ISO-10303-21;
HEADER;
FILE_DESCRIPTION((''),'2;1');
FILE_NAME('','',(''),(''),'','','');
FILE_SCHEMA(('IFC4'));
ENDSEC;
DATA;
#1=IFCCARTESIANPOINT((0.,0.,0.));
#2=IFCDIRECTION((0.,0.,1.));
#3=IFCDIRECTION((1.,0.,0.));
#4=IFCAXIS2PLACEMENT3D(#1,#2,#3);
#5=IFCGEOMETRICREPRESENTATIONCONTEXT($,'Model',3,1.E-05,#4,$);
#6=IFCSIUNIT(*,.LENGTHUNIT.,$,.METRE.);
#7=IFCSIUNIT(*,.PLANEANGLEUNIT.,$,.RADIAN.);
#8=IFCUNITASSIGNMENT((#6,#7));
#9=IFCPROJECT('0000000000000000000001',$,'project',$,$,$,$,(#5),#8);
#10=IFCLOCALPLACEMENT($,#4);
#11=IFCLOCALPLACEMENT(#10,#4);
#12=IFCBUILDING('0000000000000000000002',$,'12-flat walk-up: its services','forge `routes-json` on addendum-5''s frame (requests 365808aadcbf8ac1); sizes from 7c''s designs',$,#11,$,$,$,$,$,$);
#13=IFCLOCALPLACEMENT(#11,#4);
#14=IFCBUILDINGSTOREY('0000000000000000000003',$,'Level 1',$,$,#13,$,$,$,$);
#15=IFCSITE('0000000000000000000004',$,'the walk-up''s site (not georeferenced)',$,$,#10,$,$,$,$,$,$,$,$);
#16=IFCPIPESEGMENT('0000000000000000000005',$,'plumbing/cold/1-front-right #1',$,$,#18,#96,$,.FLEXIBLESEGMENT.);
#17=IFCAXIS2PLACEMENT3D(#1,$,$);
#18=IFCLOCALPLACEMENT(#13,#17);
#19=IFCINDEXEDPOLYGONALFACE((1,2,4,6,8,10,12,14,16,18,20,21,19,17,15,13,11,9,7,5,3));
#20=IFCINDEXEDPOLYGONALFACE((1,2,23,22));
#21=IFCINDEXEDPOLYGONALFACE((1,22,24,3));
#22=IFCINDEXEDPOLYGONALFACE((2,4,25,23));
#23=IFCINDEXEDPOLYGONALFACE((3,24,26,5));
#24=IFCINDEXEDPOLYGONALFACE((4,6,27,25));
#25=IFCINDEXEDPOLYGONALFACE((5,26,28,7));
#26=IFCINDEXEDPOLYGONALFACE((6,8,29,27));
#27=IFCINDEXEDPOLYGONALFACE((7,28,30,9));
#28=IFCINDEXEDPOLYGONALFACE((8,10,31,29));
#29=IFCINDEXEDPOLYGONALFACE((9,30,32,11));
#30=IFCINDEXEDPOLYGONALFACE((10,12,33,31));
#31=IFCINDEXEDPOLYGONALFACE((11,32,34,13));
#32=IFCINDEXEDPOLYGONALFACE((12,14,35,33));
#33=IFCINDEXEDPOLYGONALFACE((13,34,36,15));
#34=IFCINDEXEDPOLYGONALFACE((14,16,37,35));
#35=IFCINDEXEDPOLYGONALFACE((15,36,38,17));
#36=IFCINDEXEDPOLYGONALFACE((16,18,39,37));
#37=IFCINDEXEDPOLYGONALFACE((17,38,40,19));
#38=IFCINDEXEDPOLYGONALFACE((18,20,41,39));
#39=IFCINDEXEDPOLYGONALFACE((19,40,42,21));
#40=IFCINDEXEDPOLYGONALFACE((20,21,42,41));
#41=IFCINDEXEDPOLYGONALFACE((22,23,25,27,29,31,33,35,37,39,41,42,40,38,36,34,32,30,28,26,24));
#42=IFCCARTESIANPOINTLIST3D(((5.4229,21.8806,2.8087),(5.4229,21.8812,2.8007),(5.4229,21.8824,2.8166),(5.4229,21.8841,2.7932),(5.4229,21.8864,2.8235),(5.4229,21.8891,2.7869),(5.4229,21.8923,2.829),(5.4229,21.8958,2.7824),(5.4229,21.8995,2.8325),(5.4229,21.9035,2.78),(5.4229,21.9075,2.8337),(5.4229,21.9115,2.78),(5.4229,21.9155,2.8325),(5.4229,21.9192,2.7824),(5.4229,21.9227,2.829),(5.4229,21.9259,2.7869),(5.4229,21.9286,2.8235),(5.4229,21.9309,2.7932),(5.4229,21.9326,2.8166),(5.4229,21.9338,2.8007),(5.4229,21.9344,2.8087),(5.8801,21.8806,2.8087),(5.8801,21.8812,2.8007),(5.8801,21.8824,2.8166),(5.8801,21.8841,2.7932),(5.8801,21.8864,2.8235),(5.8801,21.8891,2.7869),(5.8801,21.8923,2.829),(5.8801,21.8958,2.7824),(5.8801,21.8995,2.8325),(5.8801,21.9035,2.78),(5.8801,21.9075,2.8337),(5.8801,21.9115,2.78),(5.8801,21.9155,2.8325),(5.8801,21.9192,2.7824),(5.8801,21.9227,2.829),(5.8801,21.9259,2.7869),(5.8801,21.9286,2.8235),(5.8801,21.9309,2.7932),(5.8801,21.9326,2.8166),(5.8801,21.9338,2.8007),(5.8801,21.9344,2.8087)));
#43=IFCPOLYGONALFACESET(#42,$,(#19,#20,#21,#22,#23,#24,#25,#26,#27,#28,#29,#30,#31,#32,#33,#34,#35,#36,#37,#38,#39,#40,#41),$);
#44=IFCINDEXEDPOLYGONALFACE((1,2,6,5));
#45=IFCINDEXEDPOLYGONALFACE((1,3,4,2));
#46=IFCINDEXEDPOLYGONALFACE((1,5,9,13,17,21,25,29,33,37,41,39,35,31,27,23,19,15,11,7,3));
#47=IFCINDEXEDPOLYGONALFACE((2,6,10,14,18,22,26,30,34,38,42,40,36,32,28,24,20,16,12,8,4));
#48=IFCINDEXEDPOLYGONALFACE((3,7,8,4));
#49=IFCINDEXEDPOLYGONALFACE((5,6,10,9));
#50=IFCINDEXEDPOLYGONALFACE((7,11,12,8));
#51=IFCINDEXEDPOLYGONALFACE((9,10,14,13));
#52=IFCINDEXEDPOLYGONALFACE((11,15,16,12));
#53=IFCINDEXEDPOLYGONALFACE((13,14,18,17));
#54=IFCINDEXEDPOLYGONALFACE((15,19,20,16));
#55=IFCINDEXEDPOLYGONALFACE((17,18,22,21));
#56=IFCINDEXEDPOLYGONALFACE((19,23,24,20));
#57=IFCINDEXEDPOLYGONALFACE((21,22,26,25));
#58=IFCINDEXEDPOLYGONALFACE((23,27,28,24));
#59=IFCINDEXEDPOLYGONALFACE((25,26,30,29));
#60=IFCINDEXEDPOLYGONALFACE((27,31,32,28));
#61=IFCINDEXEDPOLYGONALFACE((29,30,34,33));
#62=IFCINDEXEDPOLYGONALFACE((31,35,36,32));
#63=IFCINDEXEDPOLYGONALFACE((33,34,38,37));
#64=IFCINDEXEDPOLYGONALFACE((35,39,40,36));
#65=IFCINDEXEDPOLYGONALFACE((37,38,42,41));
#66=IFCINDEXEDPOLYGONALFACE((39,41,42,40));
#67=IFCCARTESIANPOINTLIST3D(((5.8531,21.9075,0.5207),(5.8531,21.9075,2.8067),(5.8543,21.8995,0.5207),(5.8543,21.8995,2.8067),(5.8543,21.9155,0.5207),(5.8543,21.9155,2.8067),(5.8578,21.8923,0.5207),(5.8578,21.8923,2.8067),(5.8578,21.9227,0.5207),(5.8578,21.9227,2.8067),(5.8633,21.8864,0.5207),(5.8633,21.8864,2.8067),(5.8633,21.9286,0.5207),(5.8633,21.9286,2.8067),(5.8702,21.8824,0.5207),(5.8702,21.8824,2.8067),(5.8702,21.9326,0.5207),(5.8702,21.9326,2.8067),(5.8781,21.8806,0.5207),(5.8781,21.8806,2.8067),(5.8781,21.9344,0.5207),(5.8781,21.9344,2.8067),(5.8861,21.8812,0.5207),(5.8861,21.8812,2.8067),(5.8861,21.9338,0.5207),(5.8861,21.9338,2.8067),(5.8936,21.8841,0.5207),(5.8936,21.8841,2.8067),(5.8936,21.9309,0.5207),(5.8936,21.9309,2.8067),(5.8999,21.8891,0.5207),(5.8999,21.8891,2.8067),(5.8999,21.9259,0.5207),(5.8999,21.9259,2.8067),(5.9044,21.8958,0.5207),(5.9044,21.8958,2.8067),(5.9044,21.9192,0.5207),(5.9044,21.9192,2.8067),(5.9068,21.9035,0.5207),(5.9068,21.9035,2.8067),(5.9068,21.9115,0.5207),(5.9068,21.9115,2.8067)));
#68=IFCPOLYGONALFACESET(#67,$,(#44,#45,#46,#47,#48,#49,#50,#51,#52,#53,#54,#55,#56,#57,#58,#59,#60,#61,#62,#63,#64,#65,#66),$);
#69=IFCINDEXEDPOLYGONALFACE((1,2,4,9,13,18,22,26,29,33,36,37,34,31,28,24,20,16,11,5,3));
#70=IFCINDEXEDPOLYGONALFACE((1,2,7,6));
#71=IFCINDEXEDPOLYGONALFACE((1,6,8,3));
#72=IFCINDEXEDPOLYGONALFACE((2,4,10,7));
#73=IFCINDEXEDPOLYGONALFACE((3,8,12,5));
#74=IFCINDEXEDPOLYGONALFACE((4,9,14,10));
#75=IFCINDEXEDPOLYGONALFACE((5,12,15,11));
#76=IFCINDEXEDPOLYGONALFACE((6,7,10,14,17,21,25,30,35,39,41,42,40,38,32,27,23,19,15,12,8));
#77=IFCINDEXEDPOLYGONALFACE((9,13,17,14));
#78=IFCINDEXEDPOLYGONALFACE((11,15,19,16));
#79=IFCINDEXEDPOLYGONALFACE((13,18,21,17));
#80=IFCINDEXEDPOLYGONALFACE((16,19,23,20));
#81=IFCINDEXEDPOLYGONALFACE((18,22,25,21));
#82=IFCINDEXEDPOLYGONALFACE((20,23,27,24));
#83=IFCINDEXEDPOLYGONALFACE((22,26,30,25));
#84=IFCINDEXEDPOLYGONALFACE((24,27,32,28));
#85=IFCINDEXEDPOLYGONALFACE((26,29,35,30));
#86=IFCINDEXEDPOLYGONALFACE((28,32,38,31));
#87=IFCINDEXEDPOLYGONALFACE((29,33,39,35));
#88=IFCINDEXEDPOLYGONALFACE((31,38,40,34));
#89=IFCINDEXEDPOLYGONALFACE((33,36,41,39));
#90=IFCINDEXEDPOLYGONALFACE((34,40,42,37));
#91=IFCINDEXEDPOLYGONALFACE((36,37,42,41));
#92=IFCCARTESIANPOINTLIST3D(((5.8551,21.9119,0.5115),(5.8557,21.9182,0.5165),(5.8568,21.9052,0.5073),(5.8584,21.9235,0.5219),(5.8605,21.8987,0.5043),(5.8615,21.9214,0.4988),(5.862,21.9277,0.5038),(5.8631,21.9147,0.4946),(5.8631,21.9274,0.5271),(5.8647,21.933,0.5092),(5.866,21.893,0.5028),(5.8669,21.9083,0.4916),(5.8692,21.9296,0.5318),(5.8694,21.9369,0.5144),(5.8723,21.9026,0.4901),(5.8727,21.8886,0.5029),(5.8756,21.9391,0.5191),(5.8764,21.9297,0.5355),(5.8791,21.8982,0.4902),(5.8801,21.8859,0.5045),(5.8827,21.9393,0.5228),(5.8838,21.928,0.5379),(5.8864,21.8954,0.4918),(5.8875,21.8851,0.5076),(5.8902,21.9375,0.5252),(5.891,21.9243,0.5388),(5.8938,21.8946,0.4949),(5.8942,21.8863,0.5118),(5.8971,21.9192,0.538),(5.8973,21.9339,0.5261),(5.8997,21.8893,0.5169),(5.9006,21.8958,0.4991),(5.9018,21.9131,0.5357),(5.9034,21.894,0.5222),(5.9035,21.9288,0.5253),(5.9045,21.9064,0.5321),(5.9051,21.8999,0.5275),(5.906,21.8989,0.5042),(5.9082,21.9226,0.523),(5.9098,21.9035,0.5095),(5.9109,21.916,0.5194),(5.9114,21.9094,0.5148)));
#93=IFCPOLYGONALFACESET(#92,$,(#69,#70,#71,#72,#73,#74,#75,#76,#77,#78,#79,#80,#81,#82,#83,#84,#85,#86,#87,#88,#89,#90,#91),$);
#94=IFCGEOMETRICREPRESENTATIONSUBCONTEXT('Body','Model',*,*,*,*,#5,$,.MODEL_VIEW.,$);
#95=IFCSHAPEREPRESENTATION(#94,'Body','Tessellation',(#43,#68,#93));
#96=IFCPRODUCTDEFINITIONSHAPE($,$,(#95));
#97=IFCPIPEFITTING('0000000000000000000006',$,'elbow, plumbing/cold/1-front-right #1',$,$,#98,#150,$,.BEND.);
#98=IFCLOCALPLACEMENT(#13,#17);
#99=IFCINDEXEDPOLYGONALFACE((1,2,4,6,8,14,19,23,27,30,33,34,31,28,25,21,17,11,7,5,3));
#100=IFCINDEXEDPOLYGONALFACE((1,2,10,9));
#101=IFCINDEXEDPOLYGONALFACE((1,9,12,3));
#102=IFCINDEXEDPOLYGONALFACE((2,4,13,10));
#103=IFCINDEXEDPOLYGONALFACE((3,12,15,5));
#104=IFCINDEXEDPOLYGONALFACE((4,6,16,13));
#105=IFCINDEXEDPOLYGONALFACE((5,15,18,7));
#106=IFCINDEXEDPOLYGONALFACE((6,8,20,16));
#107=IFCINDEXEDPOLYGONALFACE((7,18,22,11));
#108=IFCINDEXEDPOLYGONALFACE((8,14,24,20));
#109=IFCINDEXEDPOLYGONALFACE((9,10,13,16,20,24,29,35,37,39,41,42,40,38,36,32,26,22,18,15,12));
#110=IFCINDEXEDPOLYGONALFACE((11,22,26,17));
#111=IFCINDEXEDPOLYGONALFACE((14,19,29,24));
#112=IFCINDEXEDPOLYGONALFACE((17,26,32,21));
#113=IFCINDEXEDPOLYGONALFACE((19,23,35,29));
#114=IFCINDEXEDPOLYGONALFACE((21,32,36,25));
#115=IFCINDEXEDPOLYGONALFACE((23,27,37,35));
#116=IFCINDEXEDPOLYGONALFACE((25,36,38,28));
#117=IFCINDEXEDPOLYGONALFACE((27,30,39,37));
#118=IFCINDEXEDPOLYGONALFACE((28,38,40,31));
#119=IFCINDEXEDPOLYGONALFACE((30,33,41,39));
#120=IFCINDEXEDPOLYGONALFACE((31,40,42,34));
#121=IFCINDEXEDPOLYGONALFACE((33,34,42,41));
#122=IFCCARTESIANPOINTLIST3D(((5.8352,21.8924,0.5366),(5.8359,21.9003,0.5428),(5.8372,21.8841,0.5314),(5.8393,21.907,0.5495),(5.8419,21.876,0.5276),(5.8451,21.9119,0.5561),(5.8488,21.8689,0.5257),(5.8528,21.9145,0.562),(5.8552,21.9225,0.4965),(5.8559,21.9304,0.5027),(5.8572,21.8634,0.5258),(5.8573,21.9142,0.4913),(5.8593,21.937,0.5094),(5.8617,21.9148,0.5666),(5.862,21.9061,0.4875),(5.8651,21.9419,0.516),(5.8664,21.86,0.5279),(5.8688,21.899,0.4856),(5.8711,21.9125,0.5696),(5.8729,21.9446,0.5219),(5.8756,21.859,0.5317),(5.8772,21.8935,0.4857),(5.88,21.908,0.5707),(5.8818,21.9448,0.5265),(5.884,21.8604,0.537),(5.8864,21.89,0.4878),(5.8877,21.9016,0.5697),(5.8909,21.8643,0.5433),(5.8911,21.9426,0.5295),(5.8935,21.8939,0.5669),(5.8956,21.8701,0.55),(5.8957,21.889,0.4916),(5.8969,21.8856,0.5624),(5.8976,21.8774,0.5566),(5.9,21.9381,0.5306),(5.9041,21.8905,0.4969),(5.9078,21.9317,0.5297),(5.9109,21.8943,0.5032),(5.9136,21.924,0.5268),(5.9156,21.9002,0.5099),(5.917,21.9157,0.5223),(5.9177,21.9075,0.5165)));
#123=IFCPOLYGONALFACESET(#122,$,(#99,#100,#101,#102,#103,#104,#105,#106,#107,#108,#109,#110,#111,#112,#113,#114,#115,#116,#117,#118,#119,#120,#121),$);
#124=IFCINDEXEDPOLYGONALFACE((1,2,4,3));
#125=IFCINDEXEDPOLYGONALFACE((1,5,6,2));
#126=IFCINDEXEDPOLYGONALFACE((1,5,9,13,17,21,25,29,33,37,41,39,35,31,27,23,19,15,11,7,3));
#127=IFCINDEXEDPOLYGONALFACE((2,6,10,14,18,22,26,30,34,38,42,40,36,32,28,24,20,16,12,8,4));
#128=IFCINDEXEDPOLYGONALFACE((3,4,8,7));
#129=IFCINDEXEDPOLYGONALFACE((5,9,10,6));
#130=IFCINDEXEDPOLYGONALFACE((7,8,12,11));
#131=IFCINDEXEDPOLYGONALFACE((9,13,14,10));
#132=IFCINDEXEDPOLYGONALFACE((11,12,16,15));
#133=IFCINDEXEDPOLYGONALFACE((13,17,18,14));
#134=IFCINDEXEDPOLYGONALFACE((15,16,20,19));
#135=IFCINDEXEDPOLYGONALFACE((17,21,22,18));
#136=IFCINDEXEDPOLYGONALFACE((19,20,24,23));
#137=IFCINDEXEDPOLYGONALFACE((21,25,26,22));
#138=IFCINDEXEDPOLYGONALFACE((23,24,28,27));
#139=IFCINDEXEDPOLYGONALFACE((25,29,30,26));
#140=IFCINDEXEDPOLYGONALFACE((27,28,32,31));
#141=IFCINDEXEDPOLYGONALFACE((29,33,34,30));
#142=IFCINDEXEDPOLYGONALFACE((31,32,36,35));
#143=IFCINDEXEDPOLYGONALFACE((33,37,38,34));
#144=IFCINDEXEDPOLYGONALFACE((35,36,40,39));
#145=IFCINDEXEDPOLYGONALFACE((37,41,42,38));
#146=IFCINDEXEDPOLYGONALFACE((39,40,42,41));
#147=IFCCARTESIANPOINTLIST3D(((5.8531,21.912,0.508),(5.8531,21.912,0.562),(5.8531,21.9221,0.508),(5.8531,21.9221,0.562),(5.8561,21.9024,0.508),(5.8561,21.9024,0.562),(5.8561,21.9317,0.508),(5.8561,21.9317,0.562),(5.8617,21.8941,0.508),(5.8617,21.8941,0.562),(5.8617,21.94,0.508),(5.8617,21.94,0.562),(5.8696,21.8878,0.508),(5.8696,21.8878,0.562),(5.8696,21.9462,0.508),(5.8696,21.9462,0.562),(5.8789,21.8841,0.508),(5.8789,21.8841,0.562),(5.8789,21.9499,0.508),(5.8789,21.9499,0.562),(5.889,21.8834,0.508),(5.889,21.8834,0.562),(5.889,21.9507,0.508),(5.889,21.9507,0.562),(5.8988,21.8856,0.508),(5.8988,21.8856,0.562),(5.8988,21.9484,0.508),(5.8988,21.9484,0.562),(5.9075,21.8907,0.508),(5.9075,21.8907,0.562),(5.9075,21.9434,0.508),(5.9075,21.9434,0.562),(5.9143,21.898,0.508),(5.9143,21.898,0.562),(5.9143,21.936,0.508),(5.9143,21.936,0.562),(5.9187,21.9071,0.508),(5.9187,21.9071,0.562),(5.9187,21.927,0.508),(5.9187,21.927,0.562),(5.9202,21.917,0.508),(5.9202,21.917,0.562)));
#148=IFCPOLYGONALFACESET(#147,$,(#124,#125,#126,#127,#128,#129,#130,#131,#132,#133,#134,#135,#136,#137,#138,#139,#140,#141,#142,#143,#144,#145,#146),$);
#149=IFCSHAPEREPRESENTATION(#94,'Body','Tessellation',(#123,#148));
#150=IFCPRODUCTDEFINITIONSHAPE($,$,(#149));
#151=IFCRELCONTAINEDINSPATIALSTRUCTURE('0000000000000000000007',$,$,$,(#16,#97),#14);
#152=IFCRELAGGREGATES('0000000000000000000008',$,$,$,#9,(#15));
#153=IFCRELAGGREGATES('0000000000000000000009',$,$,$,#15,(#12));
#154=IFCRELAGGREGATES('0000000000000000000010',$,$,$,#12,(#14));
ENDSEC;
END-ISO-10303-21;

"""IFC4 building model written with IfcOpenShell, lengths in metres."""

from ifc_helpers import new_model, entity, si_unit, frame, origin_with_axes, place, context, subcontext, project, spatial, element, save


model = new_model("IFC4")

# Units and contexts
model_context = context("Model", 3, precision=1e-05, world=origin_with_axes())
body_context = subcontext(model_context, "Body", "Model", "MODEL_VIEW")
ifc_project = project(units=[si_unit("LENGTHUNIT", "METRE"), si_unit("PLANEANGLEUNIT", "RADIAN")], contexts=[model_context])

# Site, building, storey
site_placement = place(None, origin_with_axes())
site = spatial("IfcSite", under=ifc_project, at=site_placement, Name="the walk-up's site (not georeferenced)")
building_placement = place(site_placement, origin_with_axes())
building = spatial("IfcBuilding", under=site, at=building_placement, Name="12-flat walk-up: its services", Description="forge `routes-json` on addendum-5's frame (requests 365808aadcbf8ac1); sizes from 7c's designs")
storey_placement = place(building_placement, origin_with_axes())
storey = spatial("IfcBuildingStorey", under=building, at=storey_placement, Name="Level 1")

# Pipe segment
pipe_segment_1_placement = place(storey_placement, frame((5.4229, 21.9075, 2.8067), z_axis=(0.0, 0.0, 1.0), x_axis=(1.0, 0.0, 0.0)))
element("IfcPipeSegment", 1, at=pipe_segment_1_placement, inside=storey, Name="plumbing/cold/1-front-right #1", PredefinedType="FLEXIBLESEGMENT", context=body_context, shape_type="AdvancedSweptSolid", body=[
    entity("IfcSweptDiskSolid", entity("IfcPolyline", [entity("IfcCartesianPoint", [0.0, 0.0, 0.0]), entity("IfcCartesianPoint", [0.4572, 0.0, 0.0])]), 0.027),
    entity("IfcSweptDiskSolid", entity("IfcPolyline", [entity("IfcCartesianPoint", [0.4572, 0.0, 0.0]), entity("IfcCartesianPoint", [0.4572, 0.0, -2.286])]), 0.027),
    entity("IfcSweptDiskSolid", entity("IfcPolyline", [entity("IfcCartesianPoint", [0.4572, 0.0, -2.286]), entity("IfcCartesianPoint", [0.4636, 0.0095, -2.2987])]), 0.027),
])

# Pipe fitting
pipe_fitting_1_placement = place(storey_placement, frame((5.8664, 21.887, 0.5481), z_axis=(0.0, 0.0, 1.0), x_axis=(1.0, 0.0, 0.0)))
element("IfcPipeFitting", 2, at=pipe_fitting_1_placement, inside=storey, Name="elbow, plumbing/cold/1-front-right #1", PredefinedType="BEND", context=body_context, shape_type="AdvancedSweptSolid", body=[
    entity("IfcSweptDiskSolid", entity("IfcPolyline", [entity("IfcCartesianPoint", [0.0, 0.0, 0.0]), entity("IfcCartesianPoint", [0.02, 0.0301, -0.0401])]), 0.0337),
    entity("IfcSweptDiskSolid", entity("IfcPolyline", [entity("IfcCartesianPoint", [0.02, 0.0301, -0.0401]), entity("IfcCartesianPoint", [0.02, 0.0301, 0.0139])]), 0.0337),
])

save(model, "model.ifc")
